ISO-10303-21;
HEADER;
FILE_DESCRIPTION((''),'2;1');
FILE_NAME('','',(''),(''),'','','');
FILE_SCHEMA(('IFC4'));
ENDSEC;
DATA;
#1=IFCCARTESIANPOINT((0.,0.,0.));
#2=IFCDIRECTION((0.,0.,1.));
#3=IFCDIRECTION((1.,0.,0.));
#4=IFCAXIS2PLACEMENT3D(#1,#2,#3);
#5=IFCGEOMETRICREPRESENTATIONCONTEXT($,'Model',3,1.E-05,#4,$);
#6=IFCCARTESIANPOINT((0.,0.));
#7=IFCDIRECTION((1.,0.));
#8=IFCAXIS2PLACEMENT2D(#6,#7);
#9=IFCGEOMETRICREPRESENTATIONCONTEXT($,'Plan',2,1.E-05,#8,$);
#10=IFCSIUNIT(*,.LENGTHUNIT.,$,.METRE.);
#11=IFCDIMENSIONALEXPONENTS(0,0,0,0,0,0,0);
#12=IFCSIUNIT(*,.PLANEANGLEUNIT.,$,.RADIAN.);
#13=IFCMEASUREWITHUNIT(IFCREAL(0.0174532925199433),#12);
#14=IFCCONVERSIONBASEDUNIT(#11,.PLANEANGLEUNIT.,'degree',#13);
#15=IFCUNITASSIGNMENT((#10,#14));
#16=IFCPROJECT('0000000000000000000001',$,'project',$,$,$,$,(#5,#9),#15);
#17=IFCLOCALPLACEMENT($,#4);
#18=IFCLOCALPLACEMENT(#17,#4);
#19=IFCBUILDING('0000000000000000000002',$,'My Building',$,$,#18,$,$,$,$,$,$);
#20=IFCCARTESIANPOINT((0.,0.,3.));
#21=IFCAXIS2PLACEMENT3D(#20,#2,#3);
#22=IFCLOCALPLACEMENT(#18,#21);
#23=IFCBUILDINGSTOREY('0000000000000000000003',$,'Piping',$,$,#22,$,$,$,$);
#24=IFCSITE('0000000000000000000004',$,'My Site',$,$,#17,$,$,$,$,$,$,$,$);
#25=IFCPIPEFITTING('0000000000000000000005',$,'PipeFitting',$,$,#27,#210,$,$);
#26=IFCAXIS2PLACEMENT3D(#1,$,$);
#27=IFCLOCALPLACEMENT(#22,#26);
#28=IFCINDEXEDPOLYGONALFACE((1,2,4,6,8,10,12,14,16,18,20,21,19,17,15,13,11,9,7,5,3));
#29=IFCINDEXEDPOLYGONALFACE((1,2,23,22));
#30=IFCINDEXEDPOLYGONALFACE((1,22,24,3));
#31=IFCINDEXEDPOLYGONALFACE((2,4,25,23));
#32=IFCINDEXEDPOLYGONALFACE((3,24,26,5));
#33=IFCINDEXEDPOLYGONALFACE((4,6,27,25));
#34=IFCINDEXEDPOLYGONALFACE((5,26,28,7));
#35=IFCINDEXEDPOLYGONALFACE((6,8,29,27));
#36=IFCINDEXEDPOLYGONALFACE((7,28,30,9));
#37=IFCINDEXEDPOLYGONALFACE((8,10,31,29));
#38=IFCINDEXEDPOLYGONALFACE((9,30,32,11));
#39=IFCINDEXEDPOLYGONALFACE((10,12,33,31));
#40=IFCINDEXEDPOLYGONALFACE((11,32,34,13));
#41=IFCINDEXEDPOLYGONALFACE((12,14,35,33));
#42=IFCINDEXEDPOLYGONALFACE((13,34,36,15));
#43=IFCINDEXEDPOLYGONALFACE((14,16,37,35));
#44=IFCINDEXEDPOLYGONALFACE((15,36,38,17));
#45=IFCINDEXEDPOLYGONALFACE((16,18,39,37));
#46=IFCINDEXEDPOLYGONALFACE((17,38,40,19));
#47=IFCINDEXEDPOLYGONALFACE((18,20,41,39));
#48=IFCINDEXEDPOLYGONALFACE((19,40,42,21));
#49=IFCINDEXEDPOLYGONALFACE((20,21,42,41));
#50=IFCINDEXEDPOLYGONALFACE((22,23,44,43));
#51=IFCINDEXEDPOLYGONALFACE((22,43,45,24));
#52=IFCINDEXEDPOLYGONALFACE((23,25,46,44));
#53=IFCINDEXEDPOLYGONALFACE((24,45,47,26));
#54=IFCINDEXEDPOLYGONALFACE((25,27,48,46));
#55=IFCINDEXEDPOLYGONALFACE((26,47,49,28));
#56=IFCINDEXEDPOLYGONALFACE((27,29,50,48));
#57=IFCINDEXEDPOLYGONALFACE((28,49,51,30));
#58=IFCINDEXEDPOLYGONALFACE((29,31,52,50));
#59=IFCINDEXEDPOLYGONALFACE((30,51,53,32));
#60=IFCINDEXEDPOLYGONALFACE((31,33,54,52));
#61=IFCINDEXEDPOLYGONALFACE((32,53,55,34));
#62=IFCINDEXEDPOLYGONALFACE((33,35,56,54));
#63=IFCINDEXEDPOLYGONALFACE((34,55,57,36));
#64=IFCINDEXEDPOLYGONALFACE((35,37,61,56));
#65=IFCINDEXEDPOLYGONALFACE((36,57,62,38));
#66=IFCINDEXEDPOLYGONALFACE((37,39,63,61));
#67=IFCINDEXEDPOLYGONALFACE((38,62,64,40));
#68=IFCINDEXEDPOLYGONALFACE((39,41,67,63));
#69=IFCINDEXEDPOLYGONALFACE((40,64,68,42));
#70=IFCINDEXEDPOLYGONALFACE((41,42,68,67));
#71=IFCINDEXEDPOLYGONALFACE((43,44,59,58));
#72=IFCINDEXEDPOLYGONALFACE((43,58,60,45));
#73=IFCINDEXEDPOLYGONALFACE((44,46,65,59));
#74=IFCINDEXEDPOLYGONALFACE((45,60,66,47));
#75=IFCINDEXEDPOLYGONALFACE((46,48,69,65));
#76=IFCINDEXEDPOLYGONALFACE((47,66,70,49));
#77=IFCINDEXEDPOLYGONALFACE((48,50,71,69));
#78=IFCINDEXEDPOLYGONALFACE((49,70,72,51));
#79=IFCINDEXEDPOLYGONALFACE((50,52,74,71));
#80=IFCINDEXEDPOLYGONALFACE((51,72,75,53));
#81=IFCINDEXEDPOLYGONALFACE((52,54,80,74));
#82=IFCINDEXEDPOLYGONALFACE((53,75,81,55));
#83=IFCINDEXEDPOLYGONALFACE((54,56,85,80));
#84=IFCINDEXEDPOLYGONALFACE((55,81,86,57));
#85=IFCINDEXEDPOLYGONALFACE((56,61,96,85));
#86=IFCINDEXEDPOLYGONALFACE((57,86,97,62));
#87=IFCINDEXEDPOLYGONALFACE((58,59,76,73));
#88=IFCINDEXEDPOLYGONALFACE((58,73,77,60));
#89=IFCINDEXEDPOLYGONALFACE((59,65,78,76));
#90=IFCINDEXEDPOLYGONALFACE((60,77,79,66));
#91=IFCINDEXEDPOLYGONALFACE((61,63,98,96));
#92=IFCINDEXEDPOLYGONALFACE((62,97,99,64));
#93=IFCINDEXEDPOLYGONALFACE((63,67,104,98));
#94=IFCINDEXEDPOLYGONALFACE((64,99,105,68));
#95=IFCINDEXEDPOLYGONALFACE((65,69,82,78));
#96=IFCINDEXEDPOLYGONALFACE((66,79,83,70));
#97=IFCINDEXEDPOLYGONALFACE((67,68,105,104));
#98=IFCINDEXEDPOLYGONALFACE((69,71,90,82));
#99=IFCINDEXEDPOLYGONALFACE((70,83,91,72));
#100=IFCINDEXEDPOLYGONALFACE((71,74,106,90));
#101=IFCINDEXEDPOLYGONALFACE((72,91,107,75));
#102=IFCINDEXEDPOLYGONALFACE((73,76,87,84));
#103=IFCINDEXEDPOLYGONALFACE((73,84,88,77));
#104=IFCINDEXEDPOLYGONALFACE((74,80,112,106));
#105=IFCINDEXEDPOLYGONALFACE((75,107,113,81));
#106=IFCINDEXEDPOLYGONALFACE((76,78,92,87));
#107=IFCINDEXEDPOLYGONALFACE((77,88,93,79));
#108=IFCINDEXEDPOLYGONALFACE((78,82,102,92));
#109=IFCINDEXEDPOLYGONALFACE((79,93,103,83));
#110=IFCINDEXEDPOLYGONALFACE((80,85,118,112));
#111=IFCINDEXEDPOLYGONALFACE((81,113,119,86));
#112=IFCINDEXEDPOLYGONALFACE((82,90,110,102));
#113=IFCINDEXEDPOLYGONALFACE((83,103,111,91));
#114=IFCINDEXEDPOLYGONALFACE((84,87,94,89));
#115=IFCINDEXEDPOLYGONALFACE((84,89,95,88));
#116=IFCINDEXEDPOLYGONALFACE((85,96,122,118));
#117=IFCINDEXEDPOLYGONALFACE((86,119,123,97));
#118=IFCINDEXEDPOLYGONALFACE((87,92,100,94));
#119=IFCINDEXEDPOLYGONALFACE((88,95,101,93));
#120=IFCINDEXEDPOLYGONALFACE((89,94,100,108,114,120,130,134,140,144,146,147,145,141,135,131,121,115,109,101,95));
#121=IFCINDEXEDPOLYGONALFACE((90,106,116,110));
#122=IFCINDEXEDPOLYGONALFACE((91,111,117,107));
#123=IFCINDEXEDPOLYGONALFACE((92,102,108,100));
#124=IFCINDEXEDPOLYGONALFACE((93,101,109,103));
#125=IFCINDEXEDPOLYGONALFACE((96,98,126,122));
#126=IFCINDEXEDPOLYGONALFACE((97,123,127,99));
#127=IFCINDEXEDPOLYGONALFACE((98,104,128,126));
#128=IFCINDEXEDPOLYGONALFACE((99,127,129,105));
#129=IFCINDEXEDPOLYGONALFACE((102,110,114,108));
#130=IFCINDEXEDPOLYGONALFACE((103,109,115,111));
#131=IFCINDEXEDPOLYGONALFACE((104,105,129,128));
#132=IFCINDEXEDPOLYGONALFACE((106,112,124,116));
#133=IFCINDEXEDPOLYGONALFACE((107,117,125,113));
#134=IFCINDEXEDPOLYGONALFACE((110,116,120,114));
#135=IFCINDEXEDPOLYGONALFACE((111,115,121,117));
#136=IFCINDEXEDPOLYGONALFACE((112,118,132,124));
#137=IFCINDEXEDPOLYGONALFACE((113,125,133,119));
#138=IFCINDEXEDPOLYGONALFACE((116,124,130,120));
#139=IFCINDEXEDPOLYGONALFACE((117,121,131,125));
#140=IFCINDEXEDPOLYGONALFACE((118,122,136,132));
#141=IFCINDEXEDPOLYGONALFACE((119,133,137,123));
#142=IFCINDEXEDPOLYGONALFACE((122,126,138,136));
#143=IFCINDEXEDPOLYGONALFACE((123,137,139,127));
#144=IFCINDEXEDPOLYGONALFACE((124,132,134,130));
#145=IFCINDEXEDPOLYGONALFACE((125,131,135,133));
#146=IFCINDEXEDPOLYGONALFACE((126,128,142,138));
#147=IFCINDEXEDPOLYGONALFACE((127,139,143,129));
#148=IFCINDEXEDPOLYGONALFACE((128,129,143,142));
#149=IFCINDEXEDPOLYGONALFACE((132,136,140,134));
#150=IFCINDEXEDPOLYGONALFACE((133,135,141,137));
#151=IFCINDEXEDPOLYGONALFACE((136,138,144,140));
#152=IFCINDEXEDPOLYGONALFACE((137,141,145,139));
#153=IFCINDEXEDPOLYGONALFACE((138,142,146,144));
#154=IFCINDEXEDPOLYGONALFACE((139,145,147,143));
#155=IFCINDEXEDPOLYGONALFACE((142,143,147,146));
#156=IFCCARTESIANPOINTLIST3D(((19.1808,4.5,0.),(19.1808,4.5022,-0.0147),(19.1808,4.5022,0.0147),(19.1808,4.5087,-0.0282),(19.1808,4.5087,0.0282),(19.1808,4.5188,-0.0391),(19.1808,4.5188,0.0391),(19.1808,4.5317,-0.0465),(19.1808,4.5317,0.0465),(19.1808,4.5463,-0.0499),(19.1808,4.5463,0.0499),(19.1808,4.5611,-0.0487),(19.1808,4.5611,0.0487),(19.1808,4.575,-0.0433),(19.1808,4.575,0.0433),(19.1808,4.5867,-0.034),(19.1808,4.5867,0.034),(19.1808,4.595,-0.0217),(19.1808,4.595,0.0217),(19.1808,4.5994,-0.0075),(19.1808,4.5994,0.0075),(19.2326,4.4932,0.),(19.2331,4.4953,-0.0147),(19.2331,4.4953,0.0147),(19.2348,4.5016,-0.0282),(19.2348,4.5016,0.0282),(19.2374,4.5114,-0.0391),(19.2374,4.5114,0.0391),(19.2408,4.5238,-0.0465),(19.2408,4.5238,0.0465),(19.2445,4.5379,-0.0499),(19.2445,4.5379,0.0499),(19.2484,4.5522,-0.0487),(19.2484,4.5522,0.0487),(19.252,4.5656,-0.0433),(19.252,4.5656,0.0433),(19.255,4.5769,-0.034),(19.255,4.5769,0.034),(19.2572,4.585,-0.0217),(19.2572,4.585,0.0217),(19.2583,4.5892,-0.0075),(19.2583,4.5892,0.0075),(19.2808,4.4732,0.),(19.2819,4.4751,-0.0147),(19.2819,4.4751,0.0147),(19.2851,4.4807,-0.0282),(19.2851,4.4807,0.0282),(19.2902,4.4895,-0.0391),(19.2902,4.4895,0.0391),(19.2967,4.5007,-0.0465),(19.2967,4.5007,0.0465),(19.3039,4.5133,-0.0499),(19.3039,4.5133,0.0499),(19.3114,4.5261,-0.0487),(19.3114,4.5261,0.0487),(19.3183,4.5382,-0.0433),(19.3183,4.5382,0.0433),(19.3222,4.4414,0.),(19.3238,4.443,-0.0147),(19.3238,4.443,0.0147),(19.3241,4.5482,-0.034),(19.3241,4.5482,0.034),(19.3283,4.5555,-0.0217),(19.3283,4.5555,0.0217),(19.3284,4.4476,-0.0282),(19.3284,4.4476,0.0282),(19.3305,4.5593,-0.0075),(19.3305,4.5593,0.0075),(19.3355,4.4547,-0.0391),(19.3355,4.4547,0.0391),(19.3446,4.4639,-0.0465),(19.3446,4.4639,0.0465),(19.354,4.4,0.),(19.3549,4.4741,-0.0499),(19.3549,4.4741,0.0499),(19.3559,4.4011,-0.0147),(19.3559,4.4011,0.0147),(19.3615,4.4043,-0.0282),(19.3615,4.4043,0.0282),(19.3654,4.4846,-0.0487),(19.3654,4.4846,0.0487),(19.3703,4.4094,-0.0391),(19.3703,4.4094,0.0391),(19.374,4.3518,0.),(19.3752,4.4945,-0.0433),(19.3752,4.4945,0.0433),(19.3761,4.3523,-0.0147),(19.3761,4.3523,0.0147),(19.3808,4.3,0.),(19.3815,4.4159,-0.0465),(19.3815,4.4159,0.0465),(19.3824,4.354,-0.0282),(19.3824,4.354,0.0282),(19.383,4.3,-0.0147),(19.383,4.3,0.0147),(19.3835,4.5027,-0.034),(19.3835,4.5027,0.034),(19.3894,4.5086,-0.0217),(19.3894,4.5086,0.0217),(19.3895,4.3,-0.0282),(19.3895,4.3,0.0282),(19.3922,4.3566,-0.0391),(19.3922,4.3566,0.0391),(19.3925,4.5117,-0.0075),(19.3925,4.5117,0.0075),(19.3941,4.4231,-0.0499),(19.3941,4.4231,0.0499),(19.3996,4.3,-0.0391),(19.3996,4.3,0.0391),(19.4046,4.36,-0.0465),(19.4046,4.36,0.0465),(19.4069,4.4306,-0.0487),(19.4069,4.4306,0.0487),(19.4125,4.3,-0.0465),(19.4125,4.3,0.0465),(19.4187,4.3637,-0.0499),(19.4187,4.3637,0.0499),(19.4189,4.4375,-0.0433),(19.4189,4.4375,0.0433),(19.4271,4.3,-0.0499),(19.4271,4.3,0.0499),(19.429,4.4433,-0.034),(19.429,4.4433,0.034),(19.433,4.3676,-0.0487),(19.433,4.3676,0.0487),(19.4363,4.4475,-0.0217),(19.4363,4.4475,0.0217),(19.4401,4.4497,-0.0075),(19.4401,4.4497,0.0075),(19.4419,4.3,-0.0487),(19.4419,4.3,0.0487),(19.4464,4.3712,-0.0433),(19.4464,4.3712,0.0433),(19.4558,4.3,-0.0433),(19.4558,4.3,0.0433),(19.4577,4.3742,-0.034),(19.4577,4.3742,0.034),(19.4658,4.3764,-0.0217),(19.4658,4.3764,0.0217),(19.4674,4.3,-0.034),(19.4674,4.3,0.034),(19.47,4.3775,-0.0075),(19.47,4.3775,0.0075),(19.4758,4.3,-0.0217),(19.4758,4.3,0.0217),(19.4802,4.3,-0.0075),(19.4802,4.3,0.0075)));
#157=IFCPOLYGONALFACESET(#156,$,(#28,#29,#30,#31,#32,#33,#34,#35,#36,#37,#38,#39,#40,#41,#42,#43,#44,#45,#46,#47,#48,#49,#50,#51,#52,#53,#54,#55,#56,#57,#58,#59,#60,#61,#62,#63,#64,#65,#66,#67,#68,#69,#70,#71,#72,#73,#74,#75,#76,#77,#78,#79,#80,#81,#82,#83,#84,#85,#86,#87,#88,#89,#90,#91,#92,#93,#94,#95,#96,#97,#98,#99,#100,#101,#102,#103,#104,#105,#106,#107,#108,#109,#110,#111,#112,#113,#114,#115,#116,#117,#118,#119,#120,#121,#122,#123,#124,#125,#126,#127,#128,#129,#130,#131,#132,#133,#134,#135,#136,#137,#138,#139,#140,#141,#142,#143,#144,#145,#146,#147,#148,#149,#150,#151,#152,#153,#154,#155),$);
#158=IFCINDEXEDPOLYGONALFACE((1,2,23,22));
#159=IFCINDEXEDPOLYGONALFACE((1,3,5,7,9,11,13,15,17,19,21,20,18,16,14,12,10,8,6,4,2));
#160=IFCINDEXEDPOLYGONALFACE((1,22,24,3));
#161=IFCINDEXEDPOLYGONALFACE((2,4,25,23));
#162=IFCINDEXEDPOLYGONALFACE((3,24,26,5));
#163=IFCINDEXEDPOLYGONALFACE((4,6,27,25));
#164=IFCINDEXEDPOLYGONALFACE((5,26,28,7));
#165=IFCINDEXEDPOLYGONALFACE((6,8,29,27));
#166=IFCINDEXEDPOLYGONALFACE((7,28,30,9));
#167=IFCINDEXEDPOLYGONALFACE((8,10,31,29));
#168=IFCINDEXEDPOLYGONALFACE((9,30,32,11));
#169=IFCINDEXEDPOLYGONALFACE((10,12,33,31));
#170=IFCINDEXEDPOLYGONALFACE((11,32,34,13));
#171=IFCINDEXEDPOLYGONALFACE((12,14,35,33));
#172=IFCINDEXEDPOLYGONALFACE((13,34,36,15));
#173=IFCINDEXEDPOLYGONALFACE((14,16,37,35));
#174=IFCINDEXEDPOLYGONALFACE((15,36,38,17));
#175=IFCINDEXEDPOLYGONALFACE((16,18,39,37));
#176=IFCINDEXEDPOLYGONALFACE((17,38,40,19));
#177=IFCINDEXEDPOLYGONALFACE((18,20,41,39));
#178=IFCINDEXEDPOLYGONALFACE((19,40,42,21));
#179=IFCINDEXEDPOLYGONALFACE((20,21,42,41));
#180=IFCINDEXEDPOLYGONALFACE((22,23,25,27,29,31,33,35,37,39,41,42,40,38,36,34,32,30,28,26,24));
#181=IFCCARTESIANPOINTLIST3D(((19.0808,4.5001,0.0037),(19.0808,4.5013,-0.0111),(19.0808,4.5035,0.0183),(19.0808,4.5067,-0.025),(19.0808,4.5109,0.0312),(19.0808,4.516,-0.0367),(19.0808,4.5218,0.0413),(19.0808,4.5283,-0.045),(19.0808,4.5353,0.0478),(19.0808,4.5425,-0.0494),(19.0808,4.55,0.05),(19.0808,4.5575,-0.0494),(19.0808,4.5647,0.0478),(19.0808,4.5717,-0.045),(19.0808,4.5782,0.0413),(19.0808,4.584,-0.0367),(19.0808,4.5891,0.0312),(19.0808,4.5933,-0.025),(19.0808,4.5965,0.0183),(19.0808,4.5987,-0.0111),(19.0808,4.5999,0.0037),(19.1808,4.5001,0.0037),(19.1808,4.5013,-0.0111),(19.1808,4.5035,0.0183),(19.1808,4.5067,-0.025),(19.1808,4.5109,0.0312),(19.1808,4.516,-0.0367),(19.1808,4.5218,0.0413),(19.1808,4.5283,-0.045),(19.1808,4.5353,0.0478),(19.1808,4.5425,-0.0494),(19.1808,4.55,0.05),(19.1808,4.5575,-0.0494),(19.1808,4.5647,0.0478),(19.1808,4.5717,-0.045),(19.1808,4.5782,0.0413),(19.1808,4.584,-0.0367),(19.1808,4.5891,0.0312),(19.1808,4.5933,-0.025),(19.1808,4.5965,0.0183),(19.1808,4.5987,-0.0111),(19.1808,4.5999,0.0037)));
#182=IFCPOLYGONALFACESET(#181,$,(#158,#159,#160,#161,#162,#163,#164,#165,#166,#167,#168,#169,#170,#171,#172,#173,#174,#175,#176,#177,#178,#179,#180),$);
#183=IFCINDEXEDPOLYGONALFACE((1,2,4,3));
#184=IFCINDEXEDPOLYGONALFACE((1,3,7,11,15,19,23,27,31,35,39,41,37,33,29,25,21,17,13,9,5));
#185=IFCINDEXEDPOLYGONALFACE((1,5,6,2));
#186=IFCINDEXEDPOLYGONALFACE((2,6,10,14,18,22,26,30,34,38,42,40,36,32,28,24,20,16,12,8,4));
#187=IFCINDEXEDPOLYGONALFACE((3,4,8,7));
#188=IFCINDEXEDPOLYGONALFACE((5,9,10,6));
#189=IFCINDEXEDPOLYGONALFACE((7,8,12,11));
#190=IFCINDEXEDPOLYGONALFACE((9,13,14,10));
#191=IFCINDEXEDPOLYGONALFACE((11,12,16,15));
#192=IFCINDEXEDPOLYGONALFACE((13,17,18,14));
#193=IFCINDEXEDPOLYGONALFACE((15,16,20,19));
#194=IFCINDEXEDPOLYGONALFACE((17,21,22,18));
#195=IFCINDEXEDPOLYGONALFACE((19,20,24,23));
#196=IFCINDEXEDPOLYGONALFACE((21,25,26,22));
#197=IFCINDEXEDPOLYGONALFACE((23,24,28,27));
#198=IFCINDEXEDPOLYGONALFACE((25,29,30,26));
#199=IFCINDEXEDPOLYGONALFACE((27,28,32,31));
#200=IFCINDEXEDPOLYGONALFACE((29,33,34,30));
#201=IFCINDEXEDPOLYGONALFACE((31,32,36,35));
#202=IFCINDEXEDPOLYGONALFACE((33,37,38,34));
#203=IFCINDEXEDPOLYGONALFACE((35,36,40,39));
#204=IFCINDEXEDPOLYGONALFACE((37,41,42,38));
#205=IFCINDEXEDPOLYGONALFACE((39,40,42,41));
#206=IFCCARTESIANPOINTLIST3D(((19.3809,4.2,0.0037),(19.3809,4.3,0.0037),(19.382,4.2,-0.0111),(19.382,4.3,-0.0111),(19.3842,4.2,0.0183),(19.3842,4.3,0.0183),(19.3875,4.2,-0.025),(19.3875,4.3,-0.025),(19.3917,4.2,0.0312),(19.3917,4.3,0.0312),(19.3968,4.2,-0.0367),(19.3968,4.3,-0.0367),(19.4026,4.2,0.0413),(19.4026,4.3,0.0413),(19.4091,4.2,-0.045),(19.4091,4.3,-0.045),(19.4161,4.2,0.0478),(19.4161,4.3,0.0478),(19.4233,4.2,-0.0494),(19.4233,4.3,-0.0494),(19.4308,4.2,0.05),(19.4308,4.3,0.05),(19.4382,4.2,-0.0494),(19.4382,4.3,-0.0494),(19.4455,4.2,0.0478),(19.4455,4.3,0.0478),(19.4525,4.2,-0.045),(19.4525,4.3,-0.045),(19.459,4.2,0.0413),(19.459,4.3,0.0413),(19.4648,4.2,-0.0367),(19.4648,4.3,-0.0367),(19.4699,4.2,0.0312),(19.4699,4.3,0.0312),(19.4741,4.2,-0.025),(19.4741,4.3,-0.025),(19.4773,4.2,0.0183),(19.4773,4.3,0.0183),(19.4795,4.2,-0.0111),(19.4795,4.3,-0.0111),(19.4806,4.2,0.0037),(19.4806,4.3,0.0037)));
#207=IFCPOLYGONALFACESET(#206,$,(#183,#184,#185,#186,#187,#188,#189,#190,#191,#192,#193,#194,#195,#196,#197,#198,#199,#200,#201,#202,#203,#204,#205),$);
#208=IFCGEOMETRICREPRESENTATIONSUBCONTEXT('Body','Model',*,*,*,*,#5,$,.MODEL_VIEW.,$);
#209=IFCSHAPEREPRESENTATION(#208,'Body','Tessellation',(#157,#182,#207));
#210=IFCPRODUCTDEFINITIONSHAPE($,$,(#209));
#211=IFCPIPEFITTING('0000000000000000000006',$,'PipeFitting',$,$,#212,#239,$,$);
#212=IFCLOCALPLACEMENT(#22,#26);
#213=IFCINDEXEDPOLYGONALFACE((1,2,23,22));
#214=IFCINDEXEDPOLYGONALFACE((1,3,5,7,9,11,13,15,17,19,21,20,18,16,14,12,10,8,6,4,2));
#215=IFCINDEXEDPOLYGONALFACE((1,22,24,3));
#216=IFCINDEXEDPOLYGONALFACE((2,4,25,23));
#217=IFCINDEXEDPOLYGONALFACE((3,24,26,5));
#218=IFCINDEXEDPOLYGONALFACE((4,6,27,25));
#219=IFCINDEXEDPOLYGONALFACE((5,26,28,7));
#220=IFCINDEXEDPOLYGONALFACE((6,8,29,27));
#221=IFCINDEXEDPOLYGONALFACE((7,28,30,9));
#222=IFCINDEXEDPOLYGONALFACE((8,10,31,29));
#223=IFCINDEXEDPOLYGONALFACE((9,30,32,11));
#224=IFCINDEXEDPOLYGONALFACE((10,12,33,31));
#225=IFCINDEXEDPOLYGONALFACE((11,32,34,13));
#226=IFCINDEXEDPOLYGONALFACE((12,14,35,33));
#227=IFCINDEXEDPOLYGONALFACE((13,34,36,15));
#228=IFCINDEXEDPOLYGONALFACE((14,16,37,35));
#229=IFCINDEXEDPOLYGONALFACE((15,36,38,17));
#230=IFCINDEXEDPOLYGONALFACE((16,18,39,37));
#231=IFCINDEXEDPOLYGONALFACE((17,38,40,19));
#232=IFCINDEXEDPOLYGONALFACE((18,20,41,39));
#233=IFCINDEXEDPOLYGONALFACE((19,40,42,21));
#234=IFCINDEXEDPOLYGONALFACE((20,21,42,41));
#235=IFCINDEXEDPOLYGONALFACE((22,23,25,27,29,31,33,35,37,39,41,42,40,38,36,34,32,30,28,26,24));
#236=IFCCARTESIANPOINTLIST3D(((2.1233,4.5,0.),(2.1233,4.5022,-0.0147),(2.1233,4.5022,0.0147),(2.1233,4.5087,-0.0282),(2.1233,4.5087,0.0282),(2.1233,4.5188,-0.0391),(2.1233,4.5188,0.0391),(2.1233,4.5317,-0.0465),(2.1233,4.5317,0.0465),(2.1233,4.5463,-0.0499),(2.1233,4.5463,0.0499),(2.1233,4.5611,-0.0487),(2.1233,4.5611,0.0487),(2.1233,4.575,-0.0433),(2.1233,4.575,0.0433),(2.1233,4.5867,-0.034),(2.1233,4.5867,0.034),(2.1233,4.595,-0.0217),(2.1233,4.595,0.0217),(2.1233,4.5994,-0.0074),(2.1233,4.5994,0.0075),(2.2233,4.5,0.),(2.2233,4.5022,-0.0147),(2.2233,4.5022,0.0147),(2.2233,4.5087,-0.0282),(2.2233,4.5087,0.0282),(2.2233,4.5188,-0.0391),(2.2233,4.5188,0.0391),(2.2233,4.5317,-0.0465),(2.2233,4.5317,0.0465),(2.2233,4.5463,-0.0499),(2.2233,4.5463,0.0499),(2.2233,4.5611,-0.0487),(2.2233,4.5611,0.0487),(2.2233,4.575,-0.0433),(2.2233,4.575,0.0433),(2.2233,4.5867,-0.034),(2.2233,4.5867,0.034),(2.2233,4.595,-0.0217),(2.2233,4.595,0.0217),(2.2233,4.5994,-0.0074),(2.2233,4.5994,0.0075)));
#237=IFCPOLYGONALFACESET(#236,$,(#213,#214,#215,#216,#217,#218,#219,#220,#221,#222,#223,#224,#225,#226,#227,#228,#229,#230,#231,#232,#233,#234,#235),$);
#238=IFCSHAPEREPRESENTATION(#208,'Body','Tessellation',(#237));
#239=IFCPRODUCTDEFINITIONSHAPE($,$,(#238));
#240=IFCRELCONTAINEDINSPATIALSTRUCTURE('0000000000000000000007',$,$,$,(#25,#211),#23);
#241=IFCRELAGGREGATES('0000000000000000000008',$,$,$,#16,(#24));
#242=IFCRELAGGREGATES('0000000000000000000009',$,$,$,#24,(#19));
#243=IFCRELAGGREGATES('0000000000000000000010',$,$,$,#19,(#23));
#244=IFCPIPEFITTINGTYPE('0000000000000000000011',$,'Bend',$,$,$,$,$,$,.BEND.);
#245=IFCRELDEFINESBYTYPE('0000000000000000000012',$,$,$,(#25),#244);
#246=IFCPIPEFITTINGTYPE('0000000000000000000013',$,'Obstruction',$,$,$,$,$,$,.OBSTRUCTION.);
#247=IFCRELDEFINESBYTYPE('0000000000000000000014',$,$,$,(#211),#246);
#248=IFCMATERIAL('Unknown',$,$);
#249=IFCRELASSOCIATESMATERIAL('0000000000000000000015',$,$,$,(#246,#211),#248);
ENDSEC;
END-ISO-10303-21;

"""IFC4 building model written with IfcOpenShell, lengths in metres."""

from ifc_helpers import new_model, entity, si_unit, converted_unit, frame, origin_with_axes, origin_2d_with_axis, place, context, subcontext, project, spatial, circle, extrude, source, transform, mapped, material, material_profile, profile_set, profile_usage, type_object, type_shapes, element, save


model = new_model("IFC4")

# Units and contexts
model_context = context("Model", 3, precision=1e-05, world=origin_with_axes())
plan_context = context("Plan", 2, precision=1e-05, world=origin_2d_with_axis())
body_context = subcontext(model_context, "Body", "Model", "MODEL_VIEW")
ifc_project = project(units=[si_unit("LENGTHUNIT", "METRE"), converted_unit("PLANEANGLEUNIT", "degree", entity("IfcReal", 0.0174532925199433), si_unit("PLANEANGLEUNIT", "RADIAN"), dimensions=[0, 0, 0, 0, 0, 0, 0])], contexts=[model_context, plan_context])

# Site, building, storey
site_placement = place(None, origin_with_axes())
site = spatial("IfcSite", under=ifc_project, at=site_placement, Name="My Site")
building_placement = place(site_placement, origin_with_axes())
building = spatial("IfcBuilding", under=site, at=building_placement, Name="My Building")
storey_placement = place(building_placement, frame((0.0, 0.0, 3.0), z_axis=(0.0, 0.0, 1.0), x_axis=(1.0, 0.0, 0.0)))
storey = spatial("IfcBuildingStorey", under=building, at=storey_placement, Name="Piping")

# Shared definitions
ifc_material = material(Name="Unknown")

# Pipe fittings
pipe_fitting_type_1 = type_object("IfcPipeFittingType", Name="Bend", PredefinedType="BEND")
shared_shape = source(origin_with_axes(), body_context, "Body", "SolidModel", [
    entity("IfcSweptDiskSolid", entity("IfcIndexedPolyCurve", entity("IfcCartesianPointList3D", [[0.0, 0.0, -0.1], [0.0, -0.0732, -0.2768], [0.0, -0.25, -0.35]]), [entity("IfcArcIndex", [1, 2, 3])]), 0.05),
    extrude(circle(Radius=0.05), origin_with_axes(), (0.0, 0.0, -1.0), 0.1),
    extrude(circle(Radius=0.05), frame((0.0, -0.25, -0.35), z_axis=(0.0, -1.0, 0.0), x_axis=(1.0, 0.0, 0.0)), (0.0, 0.0, 1.0), 0.1),
])
type_shapes(pipe_fitting_type_1, [shared_shape])
for number, where, z_axis, x_axis, name in (
    (1, (19.0808, 4.55, 0.0), (-1.0, 0.0, 0.0), (0.0, 0.0, 1.0), "PipeFitting"),
):
    element("IfcPipeFitting", number, at=place(storey_placement, frame(where, z_axis=z_axis, x_axis=x_axis)), inside=storey, type_object=pipe_fitting_type_1, Name=name, context=body_context, shape_type="MappedRepresentation", body=[
        mapped(shared_shape, transform((0.0, 0.0, 0.0), x_axis=(1.0, 0.0, 0.0), y_axis=(0.0, 1.0, 0.0), z_axis=(0.0, 0.0, 1.0), scale=1.0)),
    ])
ifc_material_profile_1 = material_profile(ifc_material, circle(Radius=0.05))
ifc_profile_set_1 = profile_set([ifc_material_profile_1])
ifc_profile_usage_1 = profile_usage(ifc_profile_set_1, cardinal=5)
pipe_fitting_type_2 = type_object("IfcPipeFittingType", Name="Obstruction", PredefinedType="OBSTRUCTION", material=ifc_profile_set_1)
pipe_fitting_placement = place(storey_placement, frame((2.2233, 4.55, 0.0), z_axis=(-1.0, 0.0, 0.0), x_axis=(0.0, -1.0, 0.0)))
element("IfcPipeFitting", 2, at=pipe_fitting_placement, inside=storey, type_object=pipe_fitting_type_2, material=ifc_profile_usage_1, Name="PipeFitting", context=body_context, shape_type="SweptSolid", body=[
    extrude(circle(Radius=0.05), origin_with_axes(), (0.0, 0.0, 1.0), 0.1),
])

save(model, "model.ifc")
